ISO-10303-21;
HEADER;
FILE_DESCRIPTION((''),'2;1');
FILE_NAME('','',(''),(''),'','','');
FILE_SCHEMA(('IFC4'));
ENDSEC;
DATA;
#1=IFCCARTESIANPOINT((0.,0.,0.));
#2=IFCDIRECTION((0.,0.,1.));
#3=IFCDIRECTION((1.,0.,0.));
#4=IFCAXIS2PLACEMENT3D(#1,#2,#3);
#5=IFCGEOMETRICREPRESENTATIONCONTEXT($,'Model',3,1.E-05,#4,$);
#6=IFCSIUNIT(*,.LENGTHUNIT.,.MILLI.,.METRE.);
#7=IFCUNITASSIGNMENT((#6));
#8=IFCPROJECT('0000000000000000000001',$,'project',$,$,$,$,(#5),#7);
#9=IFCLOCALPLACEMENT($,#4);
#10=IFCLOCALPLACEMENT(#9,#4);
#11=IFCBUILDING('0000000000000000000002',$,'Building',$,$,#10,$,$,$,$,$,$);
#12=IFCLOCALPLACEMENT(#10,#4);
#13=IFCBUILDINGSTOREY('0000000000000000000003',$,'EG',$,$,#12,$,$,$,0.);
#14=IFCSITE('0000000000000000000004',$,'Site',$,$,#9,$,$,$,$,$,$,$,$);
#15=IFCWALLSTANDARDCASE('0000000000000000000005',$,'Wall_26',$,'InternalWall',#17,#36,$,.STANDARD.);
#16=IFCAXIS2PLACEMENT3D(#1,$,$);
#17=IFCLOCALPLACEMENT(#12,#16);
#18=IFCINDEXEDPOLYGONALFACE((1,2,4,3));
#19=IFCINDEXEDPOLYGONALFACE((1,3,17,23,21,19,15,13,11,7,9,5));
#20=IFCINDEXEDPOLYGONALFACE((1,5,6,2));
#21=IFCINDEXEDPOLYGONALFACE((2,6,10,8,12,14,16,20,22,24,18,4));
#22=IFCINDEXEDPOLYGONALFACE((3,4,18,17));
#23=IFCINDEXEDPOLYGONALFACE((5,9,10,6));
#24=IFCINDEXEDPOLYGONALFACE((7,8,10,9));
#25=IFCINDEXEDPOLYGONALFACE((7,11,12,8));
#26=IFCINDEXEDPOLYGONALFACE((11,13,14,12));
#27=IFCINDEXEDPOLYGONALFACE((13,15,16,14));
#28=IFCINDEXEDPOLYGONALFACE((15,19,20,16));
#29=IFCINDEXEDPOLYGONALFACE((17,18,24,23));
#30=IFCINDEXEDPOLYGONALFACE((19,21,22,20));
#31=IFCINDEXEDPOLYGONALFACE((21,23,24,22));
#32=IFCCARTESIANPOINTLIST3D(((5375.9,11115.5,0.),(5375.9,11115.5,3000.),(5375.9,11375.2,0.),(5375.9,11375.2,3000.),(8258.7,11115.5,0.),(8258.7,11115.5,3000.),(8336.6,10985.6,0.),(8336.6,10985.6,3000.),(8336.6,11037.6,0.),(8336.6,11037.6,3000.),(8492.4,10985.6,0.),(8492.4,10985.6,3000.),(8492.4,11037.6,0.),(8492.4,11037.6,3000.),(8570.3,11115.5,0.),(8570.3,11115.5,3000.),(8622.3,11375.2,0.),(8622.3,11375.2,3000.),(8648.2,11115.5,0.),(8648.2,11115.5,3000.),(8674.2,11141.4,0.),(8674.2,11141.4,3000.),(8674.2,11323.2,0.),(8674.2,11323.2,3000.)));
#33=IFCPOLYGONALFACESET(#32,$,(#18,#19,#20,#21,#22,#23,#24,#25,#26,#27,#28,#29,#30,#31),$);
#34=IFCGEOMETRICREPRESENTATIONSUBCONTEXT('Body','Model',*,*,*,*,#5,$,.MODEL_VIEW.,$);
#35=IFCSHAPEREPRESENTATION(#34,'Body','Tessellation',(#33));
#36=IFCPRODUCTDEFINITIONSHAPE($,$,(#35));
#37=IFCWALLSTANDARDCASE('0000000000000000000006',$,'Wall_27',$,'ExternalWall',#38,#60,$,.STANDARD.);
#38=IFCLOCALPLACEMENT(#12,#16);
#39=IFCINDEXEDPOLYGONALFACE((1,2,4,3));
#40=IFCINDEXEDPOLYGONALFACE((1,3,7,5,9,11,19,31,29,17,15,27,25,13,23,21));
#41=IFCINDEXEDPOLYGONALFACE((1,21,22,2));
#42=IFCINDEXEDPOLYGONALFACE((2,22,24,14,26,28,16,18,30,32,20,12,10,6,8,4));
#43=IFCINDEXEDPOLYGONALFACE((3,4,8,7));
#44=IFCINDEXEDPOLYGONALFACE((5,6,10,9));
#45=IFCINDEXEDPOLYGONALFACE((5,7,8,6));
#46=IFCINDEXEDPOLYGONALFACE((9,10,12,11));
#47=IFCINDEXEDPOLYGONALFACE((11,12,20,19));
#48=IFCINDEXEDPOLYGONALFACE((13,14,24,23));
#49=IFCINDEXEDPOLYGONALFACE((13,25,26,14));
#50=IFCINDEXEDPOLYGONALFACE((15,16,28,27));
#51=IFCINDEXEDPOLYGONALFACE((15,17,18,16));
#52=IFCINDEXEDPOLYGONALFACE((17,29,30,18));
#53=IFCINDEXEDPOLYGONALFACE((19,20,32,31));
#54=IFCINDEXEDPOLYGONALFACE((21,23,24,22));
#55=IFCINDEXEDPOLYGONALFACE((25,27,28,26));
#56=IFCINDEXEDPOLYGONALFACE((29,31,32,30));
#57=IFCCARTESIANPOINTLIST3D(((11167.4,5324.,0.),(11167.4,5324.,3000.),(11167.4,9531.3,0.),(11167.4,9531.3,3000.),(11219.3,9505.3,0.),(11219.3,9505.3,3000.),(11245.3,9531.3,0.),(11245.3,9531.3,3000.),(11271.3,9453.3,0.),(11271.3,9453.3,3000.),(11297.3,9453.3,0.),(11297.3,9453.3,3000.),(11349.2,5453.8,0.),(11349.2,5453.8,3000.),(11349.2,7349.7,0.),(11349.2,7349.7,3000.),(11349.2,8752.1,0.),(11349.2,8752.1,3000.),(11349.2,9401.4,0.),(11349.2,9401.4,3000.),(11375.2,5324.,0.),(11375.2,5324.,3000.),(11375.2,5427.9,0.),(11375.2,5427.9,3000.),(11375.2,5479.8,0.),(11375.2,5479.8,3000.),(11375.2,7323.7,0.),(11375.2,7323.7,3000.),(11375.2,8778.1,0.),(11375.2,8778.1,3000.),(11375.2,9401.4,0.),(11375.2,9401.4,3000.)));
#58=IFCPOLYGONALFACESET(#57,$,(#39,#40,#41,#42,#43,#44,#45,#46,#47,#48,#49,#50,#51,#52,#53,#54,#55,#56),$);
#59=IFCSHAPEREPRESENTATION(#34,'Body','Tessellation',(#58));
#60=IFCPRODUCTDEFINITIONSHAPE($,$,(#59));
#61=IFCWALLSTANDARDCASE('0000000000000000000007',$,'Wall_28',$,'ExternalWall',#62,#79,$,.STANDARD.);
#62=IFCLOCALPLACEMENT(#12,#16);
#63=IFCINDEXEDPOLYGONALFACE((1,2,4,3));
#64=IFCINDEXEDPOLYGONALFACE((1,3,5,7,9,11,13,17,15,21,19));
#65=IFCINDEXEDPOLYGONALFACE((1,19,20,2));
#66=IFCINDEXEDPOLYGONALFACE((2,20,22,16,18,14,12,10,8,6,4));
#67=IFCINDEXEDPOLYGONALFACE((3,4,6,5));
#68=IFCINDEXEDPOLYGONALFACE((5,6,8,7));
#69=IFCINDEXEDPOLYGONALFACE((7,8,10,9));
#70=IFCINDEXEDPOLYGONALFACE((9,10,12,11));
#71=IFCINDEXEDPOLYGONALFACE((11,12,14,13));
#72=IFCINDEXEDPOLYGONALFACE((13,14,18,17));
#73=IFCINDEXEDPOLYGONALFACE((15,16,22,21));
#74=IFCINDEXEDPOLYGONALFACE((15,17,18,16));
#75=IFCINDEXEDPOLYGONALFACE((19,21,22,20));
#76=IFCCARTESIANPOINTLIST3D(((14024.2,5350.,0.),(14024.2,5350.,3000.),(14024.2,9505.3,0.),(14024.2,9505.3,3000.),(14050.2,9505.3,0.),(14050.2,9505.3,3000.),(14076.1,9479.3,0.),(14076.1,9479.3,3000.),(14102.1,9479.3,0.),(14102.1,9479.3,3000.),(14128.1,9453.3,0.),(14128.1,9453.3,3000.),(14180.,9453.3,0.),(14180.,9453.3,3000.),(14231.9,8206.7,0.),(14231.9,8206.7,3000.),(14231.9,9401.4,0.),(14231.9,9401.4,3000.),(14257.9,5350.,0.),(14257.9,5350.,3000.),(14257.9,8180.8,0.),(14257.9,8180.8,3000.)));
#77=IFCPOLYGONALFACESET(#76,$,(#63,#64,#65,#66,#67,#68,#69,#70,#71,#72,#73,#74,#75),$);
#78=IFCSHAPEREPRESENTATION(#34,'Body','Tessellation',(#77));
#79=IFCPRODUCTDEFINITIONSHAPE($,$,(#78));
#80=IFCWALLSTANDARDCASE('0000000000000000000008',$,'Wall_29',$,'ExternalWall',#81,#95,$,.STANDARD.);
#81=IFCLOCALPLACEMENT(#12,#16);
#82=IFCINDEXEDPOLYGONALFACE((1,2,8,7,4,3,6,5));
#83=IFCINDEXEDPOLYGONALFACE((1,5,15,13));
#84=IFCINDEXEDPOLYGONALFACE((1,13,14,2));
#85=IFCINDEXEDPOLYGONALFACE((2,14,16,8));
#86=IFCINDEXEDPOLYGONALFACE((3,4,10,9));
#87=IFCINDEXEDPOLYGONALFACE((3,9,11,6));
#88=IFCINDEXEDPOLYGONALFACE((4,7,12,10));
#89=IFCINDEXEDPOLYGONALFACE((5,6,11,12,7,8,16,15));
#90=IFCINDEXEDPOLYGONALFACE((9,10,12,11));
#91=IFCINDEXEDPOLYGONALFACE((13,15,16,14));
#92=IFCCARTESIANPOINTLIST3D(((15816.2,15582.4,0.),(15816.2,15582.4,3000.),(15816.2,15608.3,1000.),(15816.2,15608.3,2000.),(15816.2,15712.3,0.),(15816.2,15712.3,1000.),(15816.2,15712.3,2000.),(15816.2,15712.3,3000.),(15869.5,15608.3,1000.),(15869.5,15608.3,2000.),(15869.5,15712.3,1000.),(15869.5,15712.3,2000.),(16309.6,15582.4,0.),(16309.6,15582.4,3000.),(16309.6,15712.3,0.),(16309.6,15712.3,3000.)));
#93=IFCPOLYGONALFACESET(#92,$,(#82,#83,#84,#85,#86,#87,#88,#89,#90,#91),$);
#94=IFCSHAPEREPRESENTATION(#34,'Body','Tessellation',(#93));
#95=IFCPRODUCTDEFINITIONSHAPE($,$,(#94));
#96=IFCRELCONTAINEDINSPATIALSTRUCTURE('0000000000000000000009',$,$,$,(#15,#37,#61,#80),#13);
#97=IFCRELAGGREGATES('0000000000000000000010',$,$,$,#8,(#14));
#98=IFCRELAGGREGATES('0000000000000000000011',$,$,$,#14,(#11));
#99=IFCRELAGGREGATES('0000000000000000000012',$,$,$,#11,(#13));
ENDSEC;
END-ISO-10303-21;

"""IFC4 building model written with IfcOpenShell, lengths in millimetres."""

from ifc_helpers import new_model, si_unit, frame, origin_with_axes, place, context, subcontext, project, spatial, polyline, rectangle, outline, extrude, element, save


model = new_model("IFC4")

# Units and contexts
model_context = context("Model", 3, precision=1e-05, world=origin_with_axes())
body_context = subcontext(model_context, "Body", "Model", "MODEL_VIEW")
ifc_project = project(units=[si_unit("LENGTHUNIT", "METRE", prefix="MILLI")], contexts=[model_context])

# Site, building, storey
site_placement = place(None, origin_with_axes())
site = spatial("IfcSite", under=ifc_project, at=site_placement, Name="Site")
building_placement = place(site_placement, origin_with_axes())
building = spatial("IfcBuilding", under=site, at=building_placement, Name="Building")
storey_placement = place(building_placement, origin_with_axes())
storey = spatial("IfcBuildingStorey", under=building, at=storey_placement, Name="EG", Elevation=0.0)

# Walls
wall_1_placement = place(storey_placement, origin_with_axes())
element("IfcWallStandardCase", 1, at=wall_1_placement, inside=storey, Name="Wall_26", ObjectType="InternalWall", PredefinedType="STANDARD", context=body_context, shape_type="SweptSolid", body=[
    extrude(outline(polyline([(8336.6, 10985.6, 0.0), (8336.6, 11037.6, 0.0), (8258.7, 11115.5, 0.0), (5375.9, 11115.5, 0.0), (5375.9, 11375.2, 0.0), (8622.3, 11375.2, 0.0), (8674.2, 11323.2, 0.0), (8674.2, 11141.4, 0.0), (8648.2, 11115.5, 0.0), (8570.3, 11115.5, 0.0), (8492.4, 11037.6, 0.0), (8492.4, 10985.6, 0.0), (8336.6, 10985.6, 0.0)])), origin_with_axes(), (0.0, 0.0, 1.0), 3000.0),
])
wall_2_placement = place(storey_placement, origin_with_axes())
element("IfcWallStandardCase", 2, at=wall_2_placement, inside=storey, Name="Wall_27", ObjectType="ExternalWall", PredefinedType="STANDARD", context=body_context, shape_type="SweptSolid", body=[
    extrude(outline(polyline([(11167.4, 5324.0, 0.0), (11167.4, 9531.3, 0.0), (11245.3, 9531.3, 0.0), (11219.3, 9505.3, 0.0), (11271.3, 9453.3, 0.0), (11297.3, 9453.3, 0.0), (11349.2, 9401.4, 0.0), (11375.2, 9401.4, 0.0), (11375.2, 8778.1, 0.0), (11349.2, 8752.1, 0.0), (11349.2, 7349.7, 0.0), (11375.2, 7323.7, 0.0), (11375.2, 5479.8, 0.0), (11349.2, 5453.8, 0.0), (11375.2, 5427.9, 0.0), (11375.2, 5324.0, 0.0), (11167.4, 5324.0, 0.0)])), origin_with_axes(), (0.0, 0.0, 1.0), 3000.0),
])
wall_3_placement = place(storey_placement, origin_with_axes())
element("IfcWallStandardCase", 3, at=wall_3_placement, inside=storey, Name="Wall_28", ObjectType="ExternalWall", PredefinedType="STANDARD", context=body_context, shape_type="SweptSolid", body=[
    extrude(outline(polyline([(14024.2, 5350.0, 0.0), (14024.2, 9505.3, 0.0), (14050.2, 9505.3, 0.0), (14076.1, 9479.3, 0.0), (14102.1, 9479.3, 0.0), (14128.1, 9453.3, 0.0), (14180.0, 9453.3, 0.0), (14231.9, 9401.4, 0.0), (14231.9, 8206.7, 0.0), (14257.9, 8180.8, 0.0), (14257.9, 5350.0, 0.0), (14024.2, 5350.0, 0.0)])), origin_with_axes(), (0.0, 0.0, 1.0), 3000.0),
])

# Wall, opening
wall_4_placement = place(storey_placement, origin_with_axes())
wall_4 = element("IfcWallStandardCase", 4, at=wall_4_placement, inside=storey, Name="Wall_29", ObjectType="ExternalWall", PredefinedType="STANDARD", context=body_context, shape_type="SweptSolid", body=[
    extrude(outline(polyline([(15816.2, 15582.4, 0.0), (15816.2, 15712.3, 0.0), (16309.6, 15712.3, 0.0), (16309.6, 15582.4, 0.0), (15816.2, 15582.4, 0.0)])), origin_with_axes(), (0.0, 0.0, 1.0), 3000.0),
])
opening_1_placement = place(wall_4_placement, origin_with_axes())
element("IfcOpeningElement", 5, at=opening_1_placement, inside=storey, cuts=wall_4, context=body_context, shape_type="SweptSolid", body=[
    extrude(rectangle(XDim=1200.0, YDim=129.9), frame((15269.5, 15673.2, 1000.0), z_axis=(0.0, 0.0, 1.0), x_axis=(1.0, 0.0, 0.0)), (0.0, 0.0, 1.0), 1000.0),
])

save(model, "model.ifc")
